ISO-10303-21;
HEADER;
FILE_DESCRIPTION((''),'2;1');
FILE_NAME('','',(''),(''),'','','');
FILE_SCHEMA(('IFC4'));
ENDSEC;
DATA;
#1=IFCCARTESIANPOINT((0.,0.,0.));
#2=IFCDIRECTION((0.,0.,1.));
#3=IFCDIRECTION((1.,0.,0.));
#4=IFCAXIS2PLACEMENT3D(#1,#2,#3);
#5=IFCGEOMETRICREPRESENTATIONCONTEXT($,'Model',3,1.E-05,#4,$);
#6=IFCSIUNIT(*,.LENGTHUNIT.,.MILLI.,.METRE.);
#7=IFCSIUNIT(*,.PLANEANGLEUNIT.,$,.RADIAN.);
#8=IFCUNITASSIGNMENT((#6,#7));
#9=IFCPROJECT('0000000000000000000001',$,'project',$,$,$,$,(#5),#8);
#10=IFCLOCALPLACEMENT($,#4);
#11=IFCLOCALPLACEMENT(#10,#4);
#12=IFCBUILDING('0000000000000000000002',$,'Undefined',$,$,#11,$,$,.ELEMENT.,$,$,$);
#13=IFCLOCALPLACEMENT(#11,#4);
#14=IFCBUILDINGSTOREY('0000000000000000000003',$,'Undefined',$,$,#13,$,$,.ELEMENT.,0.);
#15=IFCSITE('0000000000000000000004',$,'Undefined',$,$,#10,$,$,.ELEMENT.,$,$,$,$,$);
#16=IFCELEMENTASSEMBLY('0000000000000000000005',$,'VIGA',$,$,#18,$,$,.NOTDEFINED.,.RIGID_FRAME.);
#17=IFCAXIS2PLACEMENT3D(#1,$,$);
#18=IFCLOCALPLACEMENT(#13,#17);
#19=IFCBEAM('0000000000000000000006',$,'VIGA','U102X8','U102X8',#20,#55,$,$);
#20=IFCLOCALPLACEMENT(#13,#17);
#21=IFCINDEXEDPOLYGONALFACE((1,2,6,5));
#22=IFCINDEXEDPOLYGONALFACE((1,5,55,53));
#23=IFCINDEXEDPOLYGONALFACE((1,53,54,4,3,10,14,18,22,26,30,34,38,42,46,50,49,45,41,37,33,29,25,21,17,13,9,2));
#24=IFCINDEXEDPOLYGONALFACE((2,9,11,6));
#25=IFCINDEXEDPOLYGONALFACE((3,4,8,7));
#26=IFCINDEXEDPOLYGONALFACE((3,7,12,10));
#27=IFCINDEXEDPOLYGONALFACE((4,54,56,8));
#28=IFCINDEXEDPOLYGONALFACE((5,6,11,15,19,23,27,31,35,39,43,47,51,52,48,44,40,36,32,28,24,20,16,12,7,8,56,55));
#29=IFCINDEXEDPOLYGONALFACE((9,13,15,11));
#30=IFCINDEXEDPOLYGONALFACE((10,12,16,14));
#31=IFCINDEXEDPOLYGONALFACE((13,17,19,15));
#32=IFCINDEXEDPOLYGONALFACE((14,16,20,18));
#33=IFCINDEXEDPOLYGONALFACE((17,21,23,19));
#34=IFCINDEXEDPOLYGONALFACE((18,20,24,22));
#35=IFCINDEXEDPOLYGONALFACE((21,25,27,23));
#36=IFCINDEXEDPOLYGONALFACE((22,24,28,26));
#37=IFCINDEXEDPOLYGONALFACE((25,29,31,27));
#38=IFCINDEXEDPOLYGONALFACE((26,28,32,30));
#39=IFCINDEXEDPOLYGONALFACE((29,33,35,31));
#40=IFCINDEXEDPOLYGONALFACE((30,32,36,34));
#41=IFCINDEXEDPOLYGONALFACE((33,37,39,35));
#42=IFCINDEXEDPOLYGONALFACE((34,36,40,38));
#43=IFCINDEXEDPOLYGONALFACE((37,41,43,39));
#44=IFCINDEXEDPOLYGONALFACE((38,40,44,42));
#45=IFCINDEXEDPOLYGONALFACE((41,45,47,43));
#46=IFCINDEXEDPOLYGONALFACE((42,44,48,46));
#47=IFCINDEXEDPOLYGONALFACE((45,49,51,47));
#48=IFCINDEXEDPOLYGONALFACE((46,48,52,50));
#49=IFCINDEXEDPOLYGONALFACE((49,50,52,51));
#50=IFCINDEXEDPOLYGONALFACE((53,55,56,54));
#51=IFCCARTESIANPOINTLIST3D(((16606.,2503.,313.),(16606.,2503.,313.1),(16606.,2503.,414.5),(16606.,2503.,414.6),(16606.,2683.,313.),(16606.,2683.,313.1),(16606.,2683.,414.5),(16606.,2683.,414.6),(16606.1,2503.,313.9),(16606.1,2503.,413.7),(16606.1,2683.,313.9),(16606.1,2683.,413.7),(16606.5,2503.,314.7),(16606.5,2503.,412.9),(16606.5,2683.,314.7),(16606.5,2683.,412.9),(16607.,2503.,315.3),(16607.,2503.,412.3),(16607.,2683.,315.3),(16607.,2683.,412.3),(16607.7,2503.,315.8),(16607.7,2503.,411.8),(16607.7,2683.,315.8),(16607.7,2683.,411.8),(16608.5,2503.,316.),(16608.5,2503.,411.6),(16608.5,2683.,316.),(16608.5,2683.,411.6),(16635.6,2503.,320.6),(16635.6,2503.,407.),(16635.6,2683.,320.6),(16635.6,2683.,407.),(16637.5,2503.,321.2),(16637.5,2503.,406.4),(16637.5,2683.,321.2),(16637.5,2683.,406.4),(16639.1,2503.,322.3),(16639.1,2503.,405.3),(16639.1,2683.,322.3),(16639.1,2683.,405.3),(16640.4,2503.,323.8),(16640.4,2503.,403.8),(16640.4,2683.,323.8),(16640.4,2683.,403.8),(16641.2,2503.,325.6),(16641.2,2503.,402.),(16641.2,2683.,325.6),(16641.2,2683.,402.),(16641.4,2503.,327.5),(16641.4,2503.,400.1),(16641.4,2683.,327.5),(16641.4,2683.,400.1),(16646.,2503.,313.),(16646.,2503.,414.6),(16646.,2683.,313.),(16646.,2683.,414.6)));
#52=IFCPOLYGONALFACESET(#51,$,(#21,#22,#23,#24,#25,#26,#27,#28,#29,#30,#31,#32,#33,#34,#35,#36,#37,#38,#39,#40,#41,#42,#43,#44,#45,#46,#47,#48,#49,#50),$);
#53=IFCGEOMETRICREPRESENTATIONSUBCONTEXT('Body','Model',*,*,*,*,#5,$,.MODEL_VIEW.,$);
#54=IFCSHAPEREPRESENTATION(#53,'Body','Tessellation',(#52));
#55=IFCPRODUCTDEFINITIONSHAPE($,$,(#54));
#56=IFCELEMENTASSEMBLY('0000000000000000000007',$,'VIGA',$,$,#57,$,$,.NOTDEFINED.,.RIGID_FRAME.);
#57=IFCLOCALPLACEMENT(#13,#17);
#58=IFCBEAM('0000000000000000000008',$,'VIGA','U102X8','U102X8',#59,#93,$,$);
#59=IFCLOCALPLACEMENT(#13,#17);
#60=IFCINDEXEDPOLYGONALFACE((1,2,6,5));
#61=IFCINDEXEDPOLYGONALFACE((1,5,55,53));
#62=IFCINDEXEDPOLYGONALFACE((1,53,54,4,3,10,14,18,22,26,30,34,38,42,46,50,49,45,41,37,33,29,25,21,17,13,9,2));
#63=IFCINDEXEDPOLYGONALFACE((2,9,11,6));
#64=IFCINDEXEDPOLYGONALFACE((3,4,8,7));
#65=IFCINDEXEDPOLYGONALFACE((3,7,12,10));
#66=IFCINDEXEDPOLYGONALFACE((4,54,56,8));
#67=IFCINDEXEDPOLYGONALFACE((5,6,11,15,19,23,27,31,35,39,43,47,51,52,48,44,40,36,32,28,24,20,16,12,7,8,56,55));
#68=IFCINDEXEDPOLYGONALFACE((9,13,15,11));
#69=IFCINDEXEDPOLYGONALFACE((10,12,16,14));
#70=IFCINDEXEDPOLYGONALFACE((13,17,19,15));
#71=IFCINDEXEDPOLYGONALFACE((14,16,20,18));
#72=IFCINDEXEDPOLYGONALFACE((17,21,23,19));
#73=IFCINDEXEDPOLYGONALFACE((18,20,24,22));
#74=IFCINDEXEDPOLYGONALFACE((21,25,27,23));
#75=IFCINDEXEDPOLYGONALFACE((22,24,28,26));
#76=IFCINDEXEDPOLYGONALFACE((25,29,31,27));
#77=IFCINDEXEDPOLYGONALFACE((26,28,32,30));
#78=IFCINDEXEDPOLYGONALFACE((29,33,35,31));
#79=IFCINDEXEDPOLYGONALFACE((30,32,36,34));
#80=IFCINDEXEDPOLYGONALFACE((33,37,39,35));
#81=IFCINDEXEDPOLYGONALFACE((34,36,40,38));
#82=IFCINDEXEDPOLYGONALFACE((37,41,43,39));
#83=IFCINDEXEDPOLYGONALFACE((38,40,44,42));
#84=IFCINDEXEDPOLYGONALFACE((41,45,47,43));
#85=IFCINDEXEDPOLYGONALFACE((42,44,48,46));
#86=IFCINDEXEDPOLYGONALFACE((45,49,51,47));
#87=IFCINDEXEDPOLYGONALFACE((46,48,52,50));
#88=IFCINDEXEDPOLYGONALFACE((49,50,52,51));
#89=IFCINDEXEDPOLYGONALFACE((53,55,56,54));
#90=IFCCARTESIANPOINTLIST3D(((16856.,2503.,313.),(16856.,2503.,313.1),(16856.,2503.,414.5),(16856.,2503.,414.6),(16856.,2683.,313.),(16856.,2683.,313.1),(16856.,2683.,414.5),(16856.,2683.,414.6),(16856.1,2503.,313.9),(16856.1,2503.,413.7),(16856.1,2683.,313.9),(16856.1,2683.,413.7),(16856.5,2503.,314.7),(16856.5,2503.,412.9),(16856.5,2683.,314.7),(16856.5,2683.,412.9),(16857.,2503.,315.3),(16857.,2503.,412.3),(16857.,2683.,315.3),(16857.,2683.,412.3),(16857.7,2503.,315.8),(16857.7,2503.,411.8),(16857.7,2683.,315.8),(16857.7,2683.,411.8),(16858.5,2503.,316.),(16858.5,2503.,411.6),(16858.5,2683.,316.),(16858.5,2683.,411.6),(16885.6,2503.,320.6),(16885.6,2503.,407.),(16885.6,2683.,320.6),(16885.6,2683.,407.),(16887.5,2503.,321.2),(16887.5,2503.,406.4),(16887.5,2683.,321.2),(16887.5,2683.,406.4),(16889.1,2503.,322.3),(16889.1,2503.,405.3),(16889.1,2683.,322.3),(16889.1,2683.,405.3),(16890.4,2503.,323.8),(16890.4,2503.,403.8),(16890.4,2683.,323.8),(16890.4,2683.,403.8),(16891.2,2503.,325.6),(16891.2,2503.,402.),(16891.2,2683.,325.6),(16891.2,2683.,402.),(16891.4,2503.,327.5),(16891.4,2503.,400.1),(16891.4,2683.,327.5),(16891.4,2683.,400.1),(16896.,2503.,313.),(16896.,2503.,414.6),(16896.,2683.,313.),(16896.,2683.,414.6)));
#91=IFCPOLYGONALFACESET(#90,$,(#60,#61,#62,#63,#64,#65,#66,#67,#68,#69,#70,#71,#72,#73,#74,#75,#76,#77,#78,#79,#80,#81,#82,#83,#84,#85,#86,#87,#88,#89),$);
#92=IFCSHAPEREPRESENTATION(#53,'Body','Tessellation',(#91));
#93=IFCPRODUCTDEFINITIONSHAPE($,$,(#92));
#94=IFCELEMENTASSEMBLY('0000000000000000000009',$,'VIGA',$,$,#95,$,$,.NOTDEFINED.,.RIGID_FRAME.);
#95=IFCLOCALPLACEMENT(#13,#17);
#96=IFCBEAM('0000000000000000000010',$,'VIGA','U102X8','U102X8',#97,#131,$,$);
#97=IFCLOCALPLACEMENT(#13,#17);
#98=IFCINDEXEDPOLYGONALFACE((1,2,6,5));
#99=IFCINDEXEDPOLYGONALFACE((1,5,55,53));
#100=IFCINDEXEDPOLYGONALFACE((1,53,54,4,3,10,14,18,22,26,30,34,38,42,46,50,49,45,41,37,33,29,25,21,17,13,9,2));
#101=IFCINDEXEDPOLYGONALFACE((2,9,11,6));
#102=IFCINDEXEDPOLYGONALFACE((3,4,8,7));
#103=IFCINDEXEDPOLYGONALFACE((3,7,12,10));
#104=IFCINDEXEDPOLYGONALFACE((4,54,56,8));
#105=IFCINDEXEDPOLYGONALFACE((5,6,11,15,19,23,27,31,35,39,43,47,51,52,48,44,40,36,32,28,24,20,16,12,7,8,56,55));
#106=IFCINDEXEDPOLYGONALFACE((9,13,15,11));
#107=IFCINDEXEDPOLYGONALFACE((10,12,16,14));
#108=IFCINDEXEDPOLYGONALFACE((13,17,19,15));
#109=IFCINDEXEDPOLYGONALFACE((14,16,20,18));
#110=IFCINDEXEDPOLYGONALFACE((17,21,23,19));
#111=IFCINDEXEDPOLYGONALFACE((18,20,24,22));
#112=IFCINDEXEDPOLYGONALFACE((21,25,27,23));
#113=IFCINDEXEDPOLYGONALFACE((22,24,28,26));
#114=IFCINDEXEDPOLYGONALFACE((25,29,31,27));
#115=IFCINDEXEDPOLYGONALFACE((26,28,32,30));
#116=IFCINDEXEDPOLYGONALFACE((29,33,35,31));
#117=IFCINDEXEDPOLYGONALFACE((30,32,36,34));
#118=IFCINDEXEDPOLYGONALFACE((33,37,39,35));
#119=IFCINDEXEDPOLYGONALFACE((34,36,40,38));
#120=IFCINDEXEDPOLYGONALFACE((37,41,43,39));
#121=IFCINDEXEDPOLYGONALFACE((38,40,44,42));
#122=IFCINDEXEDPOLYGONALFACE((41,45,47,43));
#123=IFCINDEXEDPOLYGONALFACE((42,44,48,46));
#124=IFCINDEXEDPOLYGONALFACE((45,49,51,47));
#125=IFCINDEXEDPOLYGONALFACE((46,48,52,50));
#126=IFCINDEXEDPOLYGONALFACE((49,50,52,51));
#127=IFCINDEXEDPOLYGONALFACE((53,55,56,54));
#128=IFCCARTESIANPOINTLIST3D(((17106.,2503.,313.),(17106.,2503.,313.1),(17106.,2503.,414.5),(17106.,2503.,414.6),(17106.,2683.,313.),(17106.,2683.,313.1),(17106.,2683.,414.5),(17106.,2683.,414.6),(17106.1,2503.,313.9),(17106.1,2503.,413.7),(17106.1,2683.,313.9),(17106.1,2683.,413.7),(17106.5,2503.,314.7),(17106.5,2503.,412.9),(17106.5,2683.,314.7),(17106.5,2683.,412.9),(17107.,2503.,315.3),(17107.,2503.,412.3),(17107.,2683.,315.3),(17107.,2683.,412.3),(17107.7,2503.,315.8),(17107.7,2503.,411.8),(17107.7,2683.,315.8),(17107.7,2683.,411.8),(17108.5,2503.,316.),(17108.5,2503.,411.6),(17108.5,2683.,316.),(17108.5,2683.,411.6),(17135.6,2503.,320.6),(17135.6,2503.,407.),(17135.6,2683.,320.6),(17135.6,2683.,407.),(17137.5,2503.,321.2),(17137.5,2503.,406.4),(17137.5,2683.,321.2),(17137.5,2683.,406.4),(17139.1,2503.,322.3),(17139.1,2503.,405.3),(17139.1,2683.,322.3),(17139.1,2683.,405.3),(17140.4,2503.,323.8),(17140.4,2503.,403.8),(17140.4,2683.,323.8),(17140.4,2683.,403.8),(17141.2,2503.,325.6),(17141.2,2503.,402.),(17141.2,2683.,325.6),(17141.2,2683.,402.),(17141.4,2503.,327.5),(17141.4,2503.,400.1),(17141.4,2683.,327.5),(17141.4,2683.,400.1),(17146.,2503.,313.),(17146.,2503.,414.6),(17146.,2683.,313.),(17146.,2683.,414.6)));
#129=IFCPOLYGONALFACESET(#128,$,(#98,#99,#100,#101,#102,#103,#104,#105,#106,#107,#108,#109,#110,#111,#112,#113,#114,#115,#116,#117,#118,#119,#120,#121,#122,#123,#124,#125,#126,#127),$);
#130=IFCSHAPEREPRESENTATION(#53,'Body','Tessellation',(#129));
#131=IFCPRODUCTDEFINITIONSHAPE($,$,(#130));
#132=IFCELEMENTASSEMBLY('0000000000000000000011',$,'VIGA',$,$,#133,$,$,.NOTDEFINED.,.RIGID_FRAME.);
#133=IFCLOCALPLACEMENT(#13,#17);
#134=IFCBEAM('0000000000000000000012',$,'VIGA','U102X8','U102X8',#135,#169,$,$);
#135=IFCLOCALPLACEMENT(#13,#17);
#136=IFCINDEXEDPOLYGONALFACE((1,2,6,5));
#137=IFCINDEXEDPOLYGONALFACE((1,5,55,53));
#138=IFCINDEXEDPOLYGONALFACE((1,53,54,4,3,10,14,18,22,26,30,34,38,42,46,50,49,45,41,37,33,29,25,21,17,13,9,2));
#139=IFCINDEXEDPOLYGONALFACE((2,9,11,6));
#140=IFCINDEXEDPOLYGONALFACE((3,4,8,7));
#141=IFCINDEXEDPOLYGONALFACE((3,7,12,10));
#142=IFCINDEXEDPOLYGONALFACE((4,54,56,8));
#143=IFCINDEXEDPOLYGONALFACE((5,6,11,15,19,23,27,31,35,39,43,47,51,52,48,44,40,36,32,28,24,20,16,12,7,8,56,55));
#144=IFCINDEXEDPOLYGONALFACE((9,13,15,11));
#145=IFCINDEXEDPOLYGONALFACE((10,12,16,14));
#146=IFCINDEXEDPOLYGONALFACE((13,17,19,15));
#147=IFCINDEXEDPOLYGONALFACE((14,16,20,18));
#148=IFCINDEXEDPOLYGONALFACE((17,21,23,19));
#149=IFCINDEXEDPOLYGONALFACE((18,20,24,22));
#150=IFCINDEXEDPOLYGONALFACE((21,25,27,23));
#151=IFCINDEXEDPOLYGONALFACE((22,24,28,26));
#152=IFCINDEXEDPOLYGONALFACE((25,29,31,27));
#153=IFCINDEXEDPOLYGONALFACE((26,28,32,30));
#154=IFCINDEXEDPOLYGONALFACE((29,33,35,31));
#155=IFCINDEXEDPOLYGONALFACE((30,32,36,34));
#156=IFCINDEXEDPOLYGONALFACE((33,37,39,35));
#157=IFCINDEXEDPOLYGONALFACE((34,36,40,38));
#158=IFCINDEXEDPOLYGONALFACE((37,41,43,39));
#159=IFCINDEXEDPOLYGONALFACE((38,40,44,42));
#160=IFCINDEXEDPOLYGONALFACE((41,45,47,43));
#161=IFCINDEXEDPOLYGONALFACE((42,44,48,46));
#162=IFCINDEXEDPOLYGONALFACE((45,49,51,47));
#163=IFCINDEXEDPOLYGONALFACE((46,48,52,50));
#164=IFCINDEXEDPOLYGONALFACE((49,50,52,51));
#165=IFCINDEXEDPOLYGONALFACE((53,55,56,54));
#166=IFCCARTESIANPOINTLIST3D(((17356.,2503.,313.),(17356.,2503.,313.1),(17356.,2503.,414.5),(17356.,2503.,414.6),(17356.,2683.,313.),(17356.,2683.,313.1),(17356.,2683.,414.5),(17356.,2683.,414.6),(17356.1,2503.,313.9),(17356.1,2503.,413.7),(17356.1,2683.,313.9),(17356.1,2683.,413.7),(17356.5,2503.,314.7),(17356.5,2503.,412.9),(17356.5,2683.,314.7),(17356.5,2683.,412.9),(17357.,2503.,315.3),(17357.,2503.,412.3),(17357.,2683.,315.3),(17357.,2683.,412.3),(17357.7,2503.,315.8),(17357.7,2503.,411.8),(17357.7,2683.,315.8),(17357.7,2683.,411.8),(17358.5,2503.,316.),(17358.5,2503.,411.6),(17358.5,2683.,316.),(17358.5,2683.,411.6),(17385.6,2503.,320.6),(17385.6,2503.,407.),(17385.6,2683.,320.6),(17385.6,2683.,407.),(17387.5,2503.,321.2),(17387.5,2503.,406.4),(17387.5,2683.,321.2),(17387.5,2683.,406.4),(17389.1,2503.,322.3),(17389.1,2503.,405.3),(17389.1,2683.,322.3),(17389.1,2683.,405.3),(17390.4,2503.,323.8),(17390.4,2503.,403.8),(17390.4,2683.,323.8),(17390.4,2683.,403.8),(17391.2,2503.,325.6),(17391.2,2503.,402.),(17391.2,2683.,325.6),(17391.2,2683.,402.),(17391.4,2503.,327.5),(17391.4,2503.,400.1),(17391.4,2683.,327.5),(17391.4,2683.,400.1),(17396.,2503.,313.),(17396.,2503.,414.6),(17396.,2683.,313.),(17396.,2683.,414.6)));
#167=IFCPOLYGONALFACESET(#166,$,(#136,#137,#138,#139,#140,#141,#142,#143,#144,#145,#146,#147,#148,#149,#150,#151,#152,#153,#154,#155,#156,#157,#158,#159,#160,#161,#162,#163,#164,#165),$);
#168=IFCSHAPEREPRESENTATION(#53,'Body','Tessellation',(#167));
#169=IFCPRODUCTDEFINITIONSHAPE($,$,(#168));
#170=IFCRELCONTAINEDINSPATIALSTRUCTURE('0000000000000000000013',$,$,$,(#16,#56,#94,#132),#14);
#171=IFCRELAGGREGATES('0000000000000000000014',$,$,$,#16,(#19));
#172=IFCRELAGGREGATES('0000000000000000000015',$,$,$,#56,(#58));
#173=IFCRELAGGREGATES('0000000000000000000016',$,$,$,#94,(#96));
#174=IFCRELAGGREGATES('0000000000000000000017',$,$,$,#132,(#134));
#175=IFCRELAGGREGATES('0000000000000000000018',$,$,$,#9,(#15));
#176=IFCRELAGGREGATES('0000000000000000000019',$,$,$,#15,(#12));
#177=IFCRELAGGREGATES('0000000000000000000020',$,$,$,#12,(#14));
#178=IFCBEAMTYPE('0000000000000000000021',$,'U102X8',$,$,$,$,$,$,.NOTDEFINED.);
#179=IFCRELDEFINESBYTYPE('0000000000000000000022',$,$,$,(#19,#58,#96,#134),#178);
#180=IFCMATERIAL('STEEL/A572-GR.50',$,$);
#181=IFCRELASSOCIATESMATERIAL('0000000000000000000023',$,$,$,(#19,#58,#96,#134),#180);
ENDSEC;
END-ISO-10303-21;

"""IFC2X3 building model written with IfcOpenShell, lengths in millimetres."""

from ifc_helpers import new_model, si_unit, frame, origin_with_axes, origin_2d_with_axis, place, context, subcontext, project, spatial, u_section, extrude, material, type_object, element, aggregate, save


model = new_model("IFC2X3")

# Units and contexts
model_context = context("Model", 3, precision=1e-05, world=origin_with_axes())
body_context = subcontext(model_context, "Body", "Model", "MODEL_VIEW")
ifc_project = project(units=[si_unit("LENGTHUNIT", "METRE", prefix="MILLI"), si_unit("PLANEANGLEUNIT", "RADIAN")], contexts=[model_context])

# Site, building, storey
site_placement = place(None, origin_with_axes())
site = spatial("IfcSite", under=ifc_project, at=site_placement, Name="Undefined", CompositionType="ELEMENT")
building_placement = place(site_placement, origin_with_axes())
building = spatial("IfcBuilding", under=site, at=building_placement, Name="Undefined", CompositionType="ELEMENT")
storey_placement = place(building_placement, origin_with_axes())
storey = spatial("IfcBuildingStorey", under=building, at=storey_placement, Name="Undefined", CompositionType="ELEMENT", Elevation=0.0)

# Element assemblies, beams
ifc_material_1 = material(Name="STEEL/A572-GR.50")
beam_type_1 = type_object("IfcBeamType", Name="U102X8", PredefinedType="NOTDEFINED")
assembly_1_placement = place(storey_placement, origin_with_axes())
assembly_1 = element("IfcElementAssembly", 1, at=assembly_1_placement, inside=storey, Name="VIGA", AssemblyPlace="NOTDEFINED", PredefinedType="RIGID_FRAME")
beam_1_placement = place(assembly_1_placement, frame((16626.0, 2683.0, 363.8), z_axis=(0.0, 0.0, 1.0), x_axis=(0.0, -1.0, 0.0)))
beam_1 = element("IfcBeam", 2, at=beam_1_placement, type_object=beam_type_1, material=ifc_material_1, Name="VIGA", Description="U102X8", ObjectType="U102X8", context=body_context, shape_type="SweptSolid", body=[
    extrude(u_section(Depth=101.6, FlangeWidth=40.0, WebThickness=4.6, FlangeThickness=6.0, FilletRadius=7.0, EdgeRadius=3.0, FlangeSlope=0.16839, at=origin_2d_with_axis()), frame((180.0, 0.0, 0.0), z_axis=(-1.0, 0.0, 0.0), x_axis=(0.0, -1.0, 0.0)), (0.0, 0.0, 1.0), 180.0),
])
aggregate(assembly_1, [beam_1])
assembly_2_placement = place(storey_placement, origin_with_axes())
assembly_2 = element("IfcElementAssembly", 3, at=assembly_2_placement, inside=storey, Name="VIGA", AssemblyPlace="NOTDEFINED", PredefinedType="RIGID_FRAME")
beam_2_placement = place(assembly_2_placement, frame((16876.0, 2683.0, 363.8), z_axis=(0.0, 0.0, 1.0), x_axis=(0.0, -1.0, 0.0)))
beam_2 = element("IfcBeam", 4, at=beam_2_placement, type_object=beam_type_1, material=ifc_material_1, Name="VIGA", Description="U102X8", ObjectType="U102X8", context=body_context, shape_type="SweptSolid", body=[
    extrude(u_section(Depth=101.6, FlangeWidth=40.0, WebThickness=4.6, FlangeThickness=6.0, FilletRadius=7.0, EdgeRadius=3.0, FlangeSlope=0.16839, at=origin_2d_with_axis()), frame((180.0, 0.0, 0.0), z_axis=(-1.0, 0.0, 0.0), x_axis=(0.0, -1.0, 0.0)), (0.0, 0.0, 1.0), 180.0),
])
aggregate(assembly_2, [beam_2])
assembly_3_placement = place(storey_placement, origin_with_axes())
assembly_3 = element("IfcElementAssembly", 5, at=assembly_3_placement, inside=storey, Name="VIGA", AssemblyPlace="NOTDEFINED", PredefinedType="RIGID_FRAME")
beam_3_placement = place(assembly_3_placement, frame((17126.0, 2683.0, 363.8), z_axis=(0.0, 0.0, 1.0), x_axis=(0.0, -1.0, 0.0)))
beam_3 = element("IfcBeam", 6, at=beam_3_placement, type_object=beam_type_1, material=ifc_material_1, Name="VIGA", Description="U102X8", ObjectType="U102X8", context=body_context, shape_type="SweptSolid", body=[
    extrude(u_section(Depth=101.6, FlangeWidth=40.0, WebThickness=4.6, FlangeThickness=6.0, FilletRadius=7.0, EdgeRadius=3.0, FlangeSlope=0.16839, at=origin_2d_with_axis()), frame((180.0, 0.0, 0.0), z_axis=(-1.0, 0.0, 0.0), x_axis=(0.0, -1.0, 0.0)), (0.0, 0.0, 1.0), 180.0),
])
aggregate(assembly_3, [beam_3])
assembly_4_placement = place(storey_placement, origin_with_axes())
assembly_4 = element("IfcElementAssembly", 7, at=assembly_4_placement, inside=storey, Name="VIGA", AssemblyPlace="NOTDEFINED", PredefinedType="RIGID_FRAME")
beam_4_placement = place(assembly_4_placement, frame((17376.0, 2683.0, 363.8), z_axis=(0.0, 0.0, 1.0), x_axis=(0.0, -1.0, 0.0)))
beam_4 = element("IfcBeam", 8, at=beam_4_placement, type_object=beam_type_1, material=ifc_material_1, Name="VIGA", Description="U102X8", ObjectType="U102X8", context=body_context, shape_type="SweptSolid", body=[
    extrude(u_section(Depth=101.6, FlangeWidth=40.0, WebThickness=4.6, FlangeThickness=6.0, FilletRadius=7.0, EdgeRadius=3.0, FlangeSlope=0.16839, at=origin_2d_with_axis()), frame((180.0, 0.0, 0.0), z_axis=(-1.0, 0.0, 0.0), x_axis=(0.0, -1.0, 0.0)), (0.0, 0.0, 1.0), 180.0),
])
aggregate(assembly_4, [beam_4])

save(model, "model.ifc")
